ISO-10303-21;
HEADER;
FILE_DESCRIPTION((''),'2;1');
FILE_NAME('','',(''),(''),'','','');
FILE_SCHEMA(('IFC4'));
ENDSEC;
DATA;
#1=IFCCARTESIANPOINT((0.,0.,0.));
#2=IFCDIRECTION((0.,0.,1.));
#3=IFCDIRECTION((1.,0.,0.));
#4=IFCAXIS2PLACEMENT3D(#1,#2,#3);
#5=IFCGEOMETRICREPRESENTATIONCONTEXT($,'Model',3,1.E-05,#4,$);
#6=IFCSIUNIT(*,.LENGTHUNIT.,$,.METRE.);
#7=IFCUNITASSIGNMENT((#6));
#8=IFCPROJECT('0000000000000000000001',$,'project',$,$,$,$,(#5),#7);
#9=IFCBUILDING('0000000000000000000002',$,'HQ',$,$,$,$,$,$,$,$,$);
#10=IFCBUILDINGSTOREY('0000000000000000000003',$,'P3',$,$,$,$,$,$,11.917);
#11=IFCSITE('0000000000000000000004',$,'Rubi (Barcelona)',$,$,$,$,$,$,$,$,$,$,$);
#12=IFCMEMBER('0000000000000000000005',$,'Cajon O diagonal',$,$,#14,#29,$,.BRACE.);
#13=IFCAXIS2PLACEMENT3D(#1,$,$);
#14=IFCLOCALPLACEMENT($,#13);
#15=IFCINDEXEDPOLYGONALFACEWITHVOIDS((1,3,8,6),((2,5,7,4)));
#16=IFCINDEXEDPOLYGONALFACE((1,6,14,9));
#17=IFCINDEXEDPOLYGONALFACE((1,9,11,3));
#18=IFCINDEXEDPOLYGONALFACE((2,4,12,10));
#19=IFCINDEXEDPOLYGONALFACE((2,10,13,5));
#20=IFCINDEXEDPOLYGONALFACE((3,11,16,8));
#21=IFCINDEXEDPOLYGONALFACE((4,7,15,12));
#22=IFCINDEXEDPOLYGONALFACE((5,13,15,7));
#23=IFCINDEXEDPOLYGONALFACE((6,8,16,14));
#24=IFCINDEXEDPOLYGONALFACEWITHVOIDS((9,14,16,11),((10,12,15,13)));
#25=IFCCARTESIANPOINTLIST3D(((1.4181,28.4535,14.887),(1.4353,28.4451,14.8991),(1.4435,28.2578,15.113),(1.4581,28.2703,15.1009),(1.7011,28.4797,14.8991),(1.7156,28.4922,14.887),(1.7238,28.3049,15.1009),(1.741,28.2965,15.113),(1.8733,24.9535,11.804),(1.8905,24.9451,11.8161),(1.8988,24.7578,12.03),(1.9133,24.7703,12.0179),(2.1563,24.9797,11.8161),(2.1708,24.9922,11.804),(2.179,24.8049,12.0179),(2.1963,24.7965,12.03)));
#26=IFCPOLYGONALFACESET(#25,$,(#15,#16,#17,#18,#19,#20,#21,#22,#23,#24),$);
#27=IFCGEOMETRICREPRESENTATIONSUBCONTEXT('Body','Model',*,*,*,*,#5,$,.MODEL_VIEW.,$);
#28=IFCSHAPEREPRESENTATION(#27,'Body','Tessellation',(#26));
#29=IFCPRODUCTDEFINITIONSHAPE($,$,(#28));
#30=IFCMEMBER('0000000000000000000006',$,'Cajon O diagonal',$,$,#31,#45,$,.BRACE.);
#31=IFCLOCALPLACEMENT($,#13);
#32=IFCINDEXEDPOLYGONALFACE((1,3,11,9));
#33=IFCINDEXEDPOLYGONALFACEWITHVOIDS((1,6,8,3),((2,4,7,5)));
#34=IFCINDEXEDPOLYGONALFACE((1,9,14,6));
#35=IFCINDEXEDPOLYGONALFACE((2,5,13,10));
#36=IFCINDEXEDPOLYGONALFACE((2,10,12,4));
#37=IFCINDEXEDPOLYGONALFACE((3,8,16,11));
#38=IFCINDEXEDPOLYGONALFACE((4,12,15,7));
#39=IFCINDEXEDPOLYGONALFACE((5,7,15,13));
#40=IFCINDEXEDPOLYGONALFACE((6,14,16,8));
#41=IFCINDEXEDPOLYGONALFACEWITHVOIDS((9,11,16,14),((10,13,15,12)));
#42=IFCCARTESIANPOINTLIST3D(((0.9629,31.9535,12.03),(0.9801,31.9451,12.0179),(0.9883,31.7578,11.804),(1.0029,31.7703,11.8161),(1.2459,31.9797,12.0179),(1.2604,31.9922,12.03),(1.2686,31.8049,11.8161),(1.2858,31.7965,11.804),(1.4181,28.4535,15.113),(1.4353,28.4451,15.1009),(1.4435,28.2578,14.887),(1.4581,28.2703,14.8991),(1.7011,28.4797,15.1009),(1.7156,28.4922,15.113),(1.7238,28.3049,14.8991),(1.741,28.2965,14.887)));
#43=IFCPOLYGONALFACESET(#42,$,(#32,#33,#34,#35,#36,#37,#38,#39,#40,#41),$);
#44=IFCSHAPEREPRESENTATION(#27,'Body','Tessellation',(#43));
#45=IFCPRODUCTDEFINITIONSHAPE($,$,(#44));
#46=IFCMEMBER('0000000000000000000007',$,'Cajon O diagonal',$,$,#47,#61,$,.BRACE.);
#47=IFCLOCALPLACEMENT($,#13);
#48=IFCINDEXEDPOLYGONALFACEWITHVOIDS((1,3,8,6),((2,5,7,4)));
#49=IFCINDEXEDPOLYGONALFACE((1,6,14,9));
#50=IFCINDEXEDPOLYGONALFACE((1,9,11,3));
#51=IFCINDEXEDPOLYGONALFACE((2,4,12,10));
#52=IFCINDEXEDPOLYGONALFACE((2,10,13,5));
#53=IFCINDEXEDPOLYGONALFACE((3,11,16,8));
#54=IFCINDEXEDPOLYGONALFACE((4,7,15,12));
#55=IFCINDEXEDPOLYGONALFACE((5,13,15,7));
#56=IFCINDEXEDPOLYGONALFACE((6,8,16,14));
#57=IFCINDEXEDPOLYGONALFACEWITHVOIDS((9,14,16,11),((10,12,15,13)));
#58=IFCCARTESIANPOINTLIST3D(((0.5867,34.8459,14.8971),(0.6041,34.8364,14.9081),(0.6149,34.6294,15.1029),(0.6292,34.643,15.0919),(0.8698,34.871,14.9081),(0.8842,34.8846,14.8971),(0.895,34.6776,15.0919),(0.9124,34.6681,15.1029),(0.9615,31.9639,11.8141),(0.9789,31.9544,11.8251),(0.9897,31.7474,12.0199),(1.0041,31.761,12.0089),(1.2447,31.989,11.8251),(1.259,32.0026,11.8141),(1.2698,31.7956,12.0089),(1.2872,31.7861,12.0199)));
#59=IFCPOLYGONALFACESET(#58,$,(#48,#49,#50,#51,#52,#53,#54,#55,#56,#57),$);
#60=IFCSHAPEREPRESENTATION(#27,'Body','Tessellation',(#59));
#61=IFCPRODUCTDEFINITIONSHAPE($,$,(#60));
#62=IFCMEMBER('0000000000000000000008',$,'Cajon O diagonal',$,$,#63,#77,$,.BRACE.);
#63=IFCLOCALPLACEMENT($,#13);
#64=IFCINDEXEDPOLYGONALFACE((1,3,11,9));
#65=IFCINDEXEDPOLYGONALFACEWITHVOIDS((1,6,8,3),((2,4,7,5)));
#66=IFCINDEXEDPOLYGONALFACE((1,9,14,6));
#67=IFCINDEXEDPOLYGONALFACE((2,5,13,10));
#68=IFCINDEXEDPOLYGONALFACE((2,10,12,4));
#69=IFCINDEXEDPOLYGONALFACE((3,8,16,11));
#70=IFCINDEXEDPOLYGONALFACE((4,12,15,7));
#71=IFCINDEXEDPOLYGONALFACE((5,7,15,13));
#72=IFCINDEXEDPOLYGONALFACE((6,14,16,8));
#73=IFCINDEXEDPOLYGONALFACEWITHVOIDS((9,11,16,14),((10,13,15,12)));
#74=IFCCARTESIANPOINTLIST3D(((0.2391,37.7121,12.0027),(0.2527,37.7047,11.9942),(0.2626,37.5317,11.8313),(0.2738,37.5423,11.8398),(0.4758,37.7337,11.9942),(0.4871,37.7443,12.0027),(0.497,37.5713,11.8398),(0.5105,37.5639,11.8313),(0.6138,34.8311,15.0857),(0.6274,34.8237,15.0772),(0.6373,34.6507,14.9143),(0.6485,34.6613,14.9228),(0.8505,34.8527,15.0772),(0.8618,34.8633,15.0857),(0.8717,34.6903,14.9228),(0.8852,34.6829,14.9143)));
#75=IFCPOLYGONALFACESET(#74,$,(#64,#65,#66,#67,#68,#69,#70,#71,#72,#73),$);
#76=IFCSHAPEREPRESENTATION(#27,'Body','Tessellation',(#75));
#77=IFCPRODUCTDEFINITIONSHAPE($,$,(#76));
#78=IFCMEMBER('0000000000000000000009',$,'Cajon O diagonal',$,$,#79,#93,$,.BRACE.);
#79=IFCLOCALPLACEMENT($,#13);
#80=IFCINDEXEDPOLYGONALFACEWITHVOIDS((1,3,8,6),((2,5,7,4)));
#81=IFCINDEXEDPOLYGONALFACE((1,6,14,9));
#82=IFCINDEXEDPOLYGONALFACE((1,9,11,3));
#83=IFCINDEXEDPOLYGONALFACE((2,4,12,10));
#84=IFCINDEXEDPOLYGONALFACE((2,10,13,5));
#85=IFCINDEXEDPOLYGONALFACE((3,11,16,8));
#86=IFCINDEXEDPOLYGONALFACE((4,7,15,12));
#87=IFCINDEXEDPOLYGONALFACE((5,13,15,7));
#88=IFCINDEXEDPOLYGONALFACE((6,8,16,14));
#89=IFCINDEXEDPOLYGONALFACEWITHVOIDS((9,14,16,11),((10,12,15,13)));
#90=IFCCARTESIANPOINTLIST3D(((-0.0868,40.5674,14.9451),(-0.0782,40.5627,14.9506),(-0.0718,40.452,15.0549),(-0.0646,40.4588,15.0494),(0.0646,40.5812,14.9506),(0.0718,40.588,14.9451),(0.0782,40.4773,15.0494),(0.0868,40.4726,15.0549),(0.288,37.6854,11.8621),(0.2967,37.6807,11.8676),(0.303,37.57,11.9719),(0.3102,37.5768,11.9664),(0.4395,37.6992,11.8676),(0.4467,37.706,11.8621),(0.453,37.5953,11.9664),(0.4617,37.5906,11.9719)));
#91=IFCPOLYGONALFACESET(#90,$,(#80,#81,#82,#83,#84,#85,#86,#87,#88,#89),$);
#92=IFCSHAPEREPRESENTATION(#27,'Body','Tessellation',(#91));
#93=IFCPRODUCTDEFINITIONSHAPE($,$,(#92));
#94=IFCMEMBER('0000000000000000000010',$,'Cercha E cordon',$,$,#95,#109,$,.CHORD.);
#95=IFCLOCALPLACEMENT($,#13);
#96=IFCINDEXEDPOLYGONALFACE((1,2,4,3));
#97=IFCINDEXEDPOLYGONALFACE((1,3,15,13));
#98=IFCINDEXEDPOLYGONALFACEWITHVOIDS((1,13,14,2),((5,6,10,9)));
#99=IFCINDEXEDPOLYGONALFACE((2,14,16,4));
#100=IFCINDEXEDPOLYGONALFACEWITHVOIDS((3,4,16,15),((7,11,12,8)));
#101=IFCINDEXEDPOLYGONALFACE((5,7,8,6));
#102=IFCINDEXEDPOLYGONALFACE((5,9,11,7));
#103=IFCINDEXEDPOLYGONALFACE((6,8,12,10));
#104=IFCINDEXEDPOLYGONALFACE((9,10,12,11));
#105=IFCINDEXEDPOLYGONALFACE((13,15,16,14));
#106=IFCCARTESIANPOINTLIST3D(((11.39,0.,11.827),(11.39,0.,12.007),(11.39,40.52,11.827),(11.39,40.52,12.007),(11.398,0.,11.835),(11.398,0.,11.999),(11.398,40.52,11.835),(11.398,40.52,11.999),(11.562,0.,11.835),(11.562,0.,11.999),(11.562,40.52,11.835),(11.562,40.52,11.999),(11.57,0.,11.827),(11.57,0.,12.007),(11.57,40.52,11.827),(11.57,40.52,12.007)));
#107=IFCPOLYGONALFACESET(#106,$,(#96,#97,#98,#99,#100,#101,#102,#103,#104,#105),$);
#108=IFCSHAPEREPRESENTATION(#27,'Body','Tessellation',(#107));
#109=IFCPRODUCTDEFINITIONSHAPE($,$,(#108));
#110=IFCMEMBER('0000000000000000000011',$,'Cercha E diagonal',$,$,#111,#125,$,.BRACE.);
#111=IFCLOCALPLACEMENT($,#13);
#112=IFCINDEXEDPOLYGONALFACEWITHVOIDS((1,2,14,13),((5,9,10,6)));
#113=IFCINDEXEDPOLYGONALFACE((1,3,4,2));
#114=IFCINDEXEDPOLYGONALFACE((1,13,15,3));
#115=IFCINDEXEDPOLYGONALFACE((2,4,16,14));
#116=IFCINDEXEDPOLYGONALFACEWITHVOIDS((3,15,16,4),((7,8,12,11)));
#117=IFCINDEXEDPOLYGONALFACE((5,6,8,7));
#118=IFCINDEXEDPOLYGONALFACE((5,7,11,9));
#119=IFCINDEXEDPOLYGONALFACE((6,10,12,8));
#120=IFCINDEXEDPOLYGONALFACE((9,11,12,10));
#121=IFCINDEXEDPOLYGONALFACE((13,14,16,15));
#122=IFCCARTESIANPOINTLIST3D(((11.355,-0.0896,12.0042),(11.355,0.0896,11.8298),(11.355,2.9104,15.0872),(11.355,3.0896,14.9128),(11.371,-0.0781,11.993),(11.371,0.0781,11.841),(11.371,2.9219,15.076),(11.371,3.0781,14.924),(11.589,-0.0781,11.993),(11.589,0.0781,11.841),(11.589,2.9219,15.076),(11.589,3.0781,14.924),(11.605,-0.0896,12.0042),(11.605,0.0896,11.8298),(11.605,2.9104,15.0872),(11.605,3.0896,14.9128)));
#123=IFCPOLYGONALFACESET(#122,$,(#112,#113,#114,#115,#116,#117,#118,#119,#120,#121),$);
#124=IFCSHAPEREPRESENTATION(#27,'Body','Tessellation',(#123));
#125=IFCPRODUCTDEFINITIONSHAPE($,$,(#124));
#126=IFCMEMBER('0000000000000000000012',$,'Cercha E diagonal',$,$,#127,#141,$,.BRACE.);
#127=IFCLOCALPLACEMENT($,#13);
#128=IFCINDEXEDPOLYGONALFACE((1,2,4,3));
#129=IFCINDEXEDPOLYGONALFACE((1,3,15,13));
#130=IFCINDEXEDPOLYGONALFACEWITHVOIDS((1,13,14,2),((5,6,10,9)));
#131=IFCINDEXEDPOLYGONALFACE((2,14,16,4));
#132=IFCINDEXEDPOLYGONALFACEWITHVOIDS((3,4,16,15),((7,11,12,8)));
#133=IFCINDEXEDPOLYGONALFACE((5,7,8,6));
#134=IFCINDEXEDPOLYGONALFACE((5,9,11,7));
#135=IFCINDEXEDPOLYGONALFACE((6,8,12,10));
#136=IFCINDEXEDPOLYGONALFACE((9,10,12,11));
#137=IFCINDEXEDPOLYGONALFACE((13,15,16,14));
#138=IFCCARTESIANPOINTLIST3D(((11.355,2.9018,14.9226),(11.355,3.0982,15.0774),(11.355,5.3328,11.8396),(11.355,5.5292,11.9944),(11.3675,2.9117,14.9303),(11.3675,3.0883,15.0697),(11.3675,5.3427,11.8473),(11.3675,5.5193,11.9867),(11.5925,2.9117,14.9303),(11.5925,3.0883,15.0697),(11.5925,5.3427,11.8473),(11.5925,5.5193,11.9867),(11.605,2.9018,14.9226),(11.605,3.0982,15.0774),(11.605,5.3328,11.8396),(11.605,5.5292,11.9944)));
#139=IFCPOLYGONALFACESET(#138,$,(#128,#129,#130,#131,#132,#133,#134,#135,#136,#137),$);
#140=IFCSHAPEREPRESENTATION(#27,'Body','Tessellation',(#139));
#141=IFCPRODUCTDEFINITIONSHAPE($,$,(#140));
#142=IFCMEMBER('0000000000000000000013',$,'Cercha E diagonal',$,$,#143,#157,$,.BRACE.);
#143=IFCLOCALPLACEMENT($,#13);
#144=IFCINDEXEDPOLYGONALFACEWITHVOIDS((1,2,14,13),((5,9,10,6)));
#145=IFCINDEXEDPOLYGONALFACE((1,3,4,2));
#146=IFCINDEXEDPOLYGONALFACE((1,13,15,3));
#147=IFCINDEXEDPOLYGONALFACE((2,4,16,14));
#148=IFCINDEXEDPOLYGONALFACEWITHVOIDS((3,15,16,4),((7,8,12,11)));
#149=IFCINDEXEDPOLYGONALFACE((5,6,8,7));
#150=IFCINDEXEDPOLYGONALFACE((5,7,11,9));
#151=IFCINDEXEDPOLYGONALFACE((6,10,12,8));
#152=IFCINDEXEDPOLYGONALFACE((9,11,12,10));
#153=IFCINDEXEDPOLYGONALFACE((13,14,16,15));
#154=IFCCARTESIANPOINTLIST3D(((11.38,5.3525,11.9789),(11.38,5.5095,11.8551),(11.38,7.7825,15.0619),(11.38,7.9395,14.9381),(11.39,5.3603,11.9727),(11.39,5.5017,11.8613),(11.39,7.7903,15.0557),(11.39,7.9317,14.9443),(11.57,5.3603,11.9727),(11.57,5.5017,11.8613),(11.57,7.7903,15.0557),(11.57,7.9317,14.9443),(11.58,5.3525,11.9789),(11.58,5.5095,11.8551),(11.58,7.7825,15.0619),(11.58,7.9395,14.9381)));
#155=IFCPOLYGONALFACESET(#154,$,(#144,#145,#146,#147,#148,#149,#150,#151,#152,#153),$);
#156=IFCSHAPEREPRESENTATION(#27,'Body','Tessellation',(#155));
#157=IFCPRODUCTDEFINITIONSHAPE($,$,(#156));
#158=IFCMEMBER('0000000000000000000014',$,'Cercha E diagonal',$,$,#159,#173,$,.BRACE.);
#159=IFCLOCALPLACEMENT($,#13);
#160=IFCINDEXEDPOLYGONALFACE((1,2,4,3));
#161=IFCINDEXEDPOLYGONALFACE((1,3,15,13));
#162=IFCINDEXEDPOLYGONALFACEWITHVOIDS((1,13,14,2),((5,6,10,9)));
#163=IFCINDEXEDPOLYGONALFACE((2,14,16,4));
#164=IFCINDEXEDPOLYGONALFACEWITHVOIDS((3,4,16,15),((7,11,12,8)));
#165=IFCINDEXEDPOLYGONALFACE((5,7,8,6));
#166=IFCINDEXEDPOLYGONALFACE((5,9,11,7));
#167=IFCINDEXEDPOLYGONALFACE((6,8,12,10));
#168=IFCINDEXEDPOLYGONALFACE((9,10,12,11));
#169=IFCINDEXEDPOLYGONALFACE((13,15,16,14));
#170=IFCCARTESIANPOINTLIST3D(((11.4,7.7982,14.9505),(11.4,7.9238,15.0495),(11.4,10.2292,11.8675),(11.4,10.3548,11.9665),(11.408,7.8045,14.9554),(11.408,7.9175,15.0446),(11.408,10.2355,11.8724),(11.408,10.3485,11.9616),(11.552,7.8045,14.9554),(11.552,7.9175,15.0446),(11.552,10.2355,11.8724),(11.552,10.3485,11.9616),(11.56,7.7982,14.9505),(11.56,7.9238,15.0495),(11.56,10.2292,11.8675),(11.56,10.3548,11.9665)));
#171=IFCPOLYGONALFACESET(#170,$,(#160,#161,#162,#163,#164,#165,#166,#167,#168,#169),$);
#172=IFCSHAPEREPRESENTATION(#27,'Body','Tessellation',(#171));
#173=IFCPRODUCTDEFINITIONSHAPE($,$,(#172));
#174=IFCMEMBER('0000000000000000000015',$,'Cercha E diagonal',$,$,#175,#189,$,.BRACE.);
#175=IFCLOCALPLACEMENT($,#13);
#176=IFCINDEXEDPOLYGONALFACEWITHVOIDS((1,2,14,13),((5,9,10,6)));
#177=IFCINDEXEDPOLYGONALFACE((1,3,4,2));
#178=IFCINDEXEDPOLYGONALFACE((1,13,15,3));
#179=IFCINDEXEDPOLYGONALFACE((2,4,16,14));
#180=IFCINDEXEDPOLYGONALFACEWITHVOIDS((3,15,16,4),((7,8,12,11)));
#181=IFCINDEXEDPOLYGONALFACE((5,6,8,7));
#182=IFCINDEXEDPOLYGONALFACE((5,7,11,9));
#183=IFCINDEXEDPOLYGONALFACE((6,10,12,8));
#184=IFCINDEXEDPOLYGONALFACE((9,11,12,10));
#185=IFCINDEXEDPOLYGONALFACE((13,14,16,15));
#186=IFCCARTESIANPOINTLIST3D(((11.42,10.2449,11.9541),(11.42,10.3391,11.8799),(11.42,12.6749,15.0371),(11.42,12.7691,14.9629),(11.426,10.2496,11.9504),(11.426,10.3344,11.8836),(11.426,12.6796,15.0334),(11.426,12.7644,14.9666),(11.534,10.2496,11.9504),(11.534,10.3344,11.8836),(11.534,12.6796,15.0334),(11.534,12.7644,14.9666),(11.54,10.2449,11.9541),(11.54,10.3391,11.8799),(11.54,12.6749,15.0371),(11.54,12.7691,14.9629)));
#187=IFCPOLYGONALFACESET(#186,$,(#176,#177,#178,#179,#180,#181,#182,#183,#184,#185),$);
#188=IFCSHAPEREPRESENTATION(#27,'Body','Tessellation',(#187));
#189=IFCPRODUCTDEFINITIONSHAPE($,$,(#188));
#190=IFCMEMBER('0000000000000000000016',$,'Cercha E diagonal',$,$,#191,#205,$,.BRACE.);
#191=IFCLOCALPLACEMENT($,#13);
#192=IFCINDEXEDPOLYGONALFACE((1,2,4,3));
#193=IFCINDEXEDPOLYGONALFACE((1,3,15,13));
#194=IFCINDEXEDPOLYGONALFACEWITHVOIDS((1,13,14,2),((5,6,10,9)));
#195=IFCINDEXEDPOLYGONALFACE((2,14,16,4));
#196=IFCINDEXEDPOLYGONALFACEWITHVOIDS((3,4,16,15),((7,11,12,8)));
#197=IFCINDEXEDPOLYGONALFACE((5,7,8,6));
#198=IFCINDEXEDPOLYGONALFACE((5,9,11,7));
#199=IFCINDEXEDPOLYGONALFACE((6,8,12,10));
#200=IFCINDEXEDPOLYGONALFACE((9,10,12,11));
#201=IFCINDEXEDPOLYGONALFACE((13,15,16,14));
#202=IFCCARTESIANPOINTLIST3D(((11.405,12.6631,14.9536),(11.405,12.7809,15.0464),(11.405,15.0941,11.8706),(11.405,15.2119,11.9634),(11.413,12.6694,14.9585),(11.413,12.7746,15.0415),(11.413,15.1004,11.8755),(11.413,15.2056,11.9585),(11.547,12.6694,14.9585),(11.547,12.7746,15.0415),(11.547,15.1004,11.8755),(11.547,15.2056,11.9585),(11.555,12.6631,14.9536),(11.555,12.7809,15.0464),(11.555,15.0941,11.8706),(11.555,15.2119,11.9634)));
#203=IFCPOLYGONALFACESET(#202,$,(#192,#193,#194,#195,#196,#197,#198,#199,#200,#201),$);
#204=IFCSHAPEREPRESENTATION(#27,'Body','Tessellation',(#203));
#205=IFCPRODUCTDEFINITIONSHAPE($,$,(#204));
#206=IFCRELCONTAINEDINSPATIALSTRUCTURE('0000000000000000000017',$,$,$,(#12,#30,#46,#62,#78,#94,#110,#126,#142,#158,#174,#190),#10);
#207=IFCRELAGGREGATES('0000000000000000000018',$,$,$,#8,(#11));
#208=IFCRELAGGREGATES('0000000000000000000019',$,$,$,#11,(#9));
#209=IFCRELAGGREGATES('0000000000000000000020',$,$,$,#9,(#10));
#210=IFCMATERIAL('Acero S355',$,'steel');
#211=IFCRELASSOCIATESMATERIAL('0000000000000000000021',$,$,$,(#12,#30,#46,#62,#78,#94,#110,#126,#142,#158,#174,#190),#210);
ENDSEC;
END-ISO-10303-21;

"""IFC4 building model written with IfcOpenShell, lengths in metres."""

from ifc_helpers import new_model, si_unit, frame, origin_with_axes, place, context, subcontext, project, spatial, hollow_rectangle, extrude, material, element, save


model = new_model("IFC4")

# Units and contexts
model_context = context("Model", 3, precision=1e-05, world=origin_with_axes())
body_context = subcontext(model_context, "Body", "Model", "MODEL_VIEW")
ifc_project = project(units=[si_unit("LENGTHUNIT", "METRE")], contexts=[model_context])

# Site, building, storey
site = spatial("IfcSite", under=ifc_project, Name="Rubi (Barcelona)")
building = spatial("IfcBuilding", under=site, Name="HQ")
storey = spatial("IfcBuildingStorey", under=building, Name="P3", Elevation=11.917)

# Members
ifc_material = material(Name="Acero S355", Category="steel")
member_1_placement = place(None, origin_with_axes())
element("IfcMember", 1, at=member_1_placement, inside=storey, material=ifc_material, Name="Cajon O diagonal", PredefinedType="BRACE", context=body_context, shape_type="SweptSolid", body=[
    extrude(hollow_rectangle(XDim=0.3, YDim=0.3, WallThickness=0.016), frame((2.0348, 24.875, 11.917), z_axis=(-0.097134, 0.746846, 0.657865), x_axis=(-0.991648, -0.128973, 0.0)), (0.0, 0.0, 1.0), 4.6864),
])
member_2_placement = place(None, origin_with_axes())
element("IfcMember", 2, at=member_2_placement, inside=storey, material=ifc_material, Name="Cajon O diagonal", PredefinedType="BRACE", context=body_context, shape_type="SweptSolid", body=[
    extrude(hollow_rectangle(XDim=0.3, YDim=0.3, WallThickness=0.016), frame((1.1244, 31.875, 11.917), z_axis=(0.097134, -0.746846, 0.657865), x_axis=(0.991648, 0.128973, 0.0)), (0.0, 0.0, 1.0), 4.6864),
])
member_3_placement = place(None, origin_with_axes())
element("IfcMember", 3, at=member_3_placement, inside=storey, material=ifc_material, Name="Cajon O diagonal", PredefinedType="BRACE", context=body_context, shape_type="SweptSolid", body=[
    extrude(hollow_rectangle(XDim=0.3, YDim=0.3, WallThickness=0.016), frame((1.1244, 31.875, 11.917), z_axis=(-0.088468, 0.680215, 0.727655), x_axis=(-0.991648, -0.128973, 0.0)), (0.0, 0.0, 1.0), 4.2369),
])
member_4_placement = place(None, origin_with_axes())
element("IfcMember", 4, at=member_4_placement, inside=storey, material=ifc_material, Name="Cajon O diagonal", PredefinedType="BRACE", context=body_context, shape_type="SweptSolid", body=[
    extrude(hollow_rectangle(XDim=0.25, YDim=0.25, WallThickness=0.0125), frame((0.3748, 37.638, 11.917), z_axis=(0.088452, -0.68009, 0.727774), x_axis=(0.991648, 0.128973, 0.0)), (0.0, 0.0, 1.0), 4.2362),
])
member_5_placement = place(None, origin_with_axes())
element("IfcMember", 5, at=member_5_placement, inside=storey, material=ifc_material, Name="Cajon O diagonal", PredefinedType="BRACE", context=body_context, shape_type="SweptSolid", body=[
    extrude(hollow_rectangle(XDim=0.16, YDim=0.16, WallThickness=0.008), frame((0.3748, 37.638, 11.917), z_axis=(-0.088468, 0.680215, 0.727655), x_axis=(-0.991648, -0.128973, 0.0)), (0.0, 0.0, 1.0), 4.2369),
])
member_6_placement = place(None, origin_with_axes())
element("IfcMember", 6, at=member_6_placement, inside=storey, material=ifc_material, Name="Cercha E cordon", PredefinedType="CHORD", context=body_context, shape_type="SweptSolid", body=[
    extrude(hollow_rectangle(XDim=0.18, YDim=0.18, WallThickness=0.008), frame((11.48, 0.0, 11.917), z_axis=(0.0, 1.0, 0.0), x_axis=(-1.0, 0.0, 0.0)), (0.0, 0.0, 1.0), 40.52),
])
member_7_placement = place(None, origin_with_axes())
element("IfcMember", 7, at=member_7_placement, inside=storey, material=ifc_material, Name="Cercha E diagonal", PredefinedType="BRACE", context=body_context, shape_type="SweptSolid", body=[
    extrude(hollow_rectangle(XDim=0.25, YDim=0.25, WallThickness=0.016), frame((11.48, 0.0, 11.917), z_axis=(0.0, 0.697394, 0.716688), x_axis=(-1.0, 0.0, 0.0)), (0.0, 0.0, 1.0), 4.3017),
])
member_8_placement = place(None, origin_with_axes())
element("IfcMember", 8, at=member_8_placement, inside=storey, material=ifc_material, Name="Cercha E diagonal", PredefinedType="BRACE", context=body_context, shape_type="SweptSolid", body=[
    extrude(hollow_rectangle(XDim=0.25, YDim=0.25, WallThickness=0.0125), frame((11.48, 5.431, 11.917), z_axis=(0.0, -0.619182, 0.785248), x_axis=(1.0, 0.0, 0.0)), (0.0, 0.0, 1.0), 3.9261),
])
member_9_placement = place(None, origin_with_axes())
element("IfcMember", 9, at=member_9_placement, inside=storey, material=ifc_material, Name="Cercha E diagonal", PredefinedType="BRACE", context=body_context, shape_type="SweptSolid", body=[
    extrude(hollow_rectangle(XDim=0.2, YDim=0.2, WallThickness=0.01), frame((11.48, 5.431, 11.917), z_axis=(0.0, 0.619025, 0.785372), x_axis=(-1.0, 0.0, 0.0)), (0.0, 0.0, 1.0), 3.9255),
])
member_10_placement = place(None, origin_with_axes())
element("IfcMember", 10, at=member_10_placement, inside=storey, material=ifc_material, Name="Cercha E diagonal", PredefinedType="BRACE", context=body_context, shape_type="SweptSolid", body=[
    extrude(hollow_rectangle(XDim=0.16, YDim=0.16, WallThickness=0.008), frame((11.48, 10.292, 11.917), z_axis=(0.0, -0.619182, 0.785248), x_axis=(1.0, 0.0, 0.0)), (0.0, 0.0, 1.0), 3.9261),
])
member_11_placement = place(None, origin_with_axes())
element("IfcMember", 11, at=member_11_placement, inside=storey, material=ifc_material, Name="Cercha E diagonal", PredefinedType="BRACE", context=body_context, shape_type="SweptSolid", body=[
    extrude(hollow_rectangle(XDim=0.12, YDim=0.12, WallThickness=0.006), frame((11.48, 10.292, 11.917), z_axis=(0.0, 0.619025, 0.785372), x_axis=(-1.0, 0.0, 0.0)), (0.0, 0.0, 1.0), 3.9255),
])
member_12_placement = place(None, origin_with_axes())
element("IfcMember", 12, at=member_12_placement, inside=storey, material=ifc_material, Name="Cercha E diagonal", PredefinedType="BRACE", context=body_context, shape_type="SweptSolid", body=[
    extrude(hollow_rectangle(XDim=0.15, YDim=0.15, WallThickness=0.008), frame((11.48, 15.153, 11.917), z_axis=(0.0, -0.619182, 0.785248), x_axis=(1.0, 0.0, 0.0)), (0.0, 0.0, 1.0), 3.9261),
])

save(model, "model.ifc")
